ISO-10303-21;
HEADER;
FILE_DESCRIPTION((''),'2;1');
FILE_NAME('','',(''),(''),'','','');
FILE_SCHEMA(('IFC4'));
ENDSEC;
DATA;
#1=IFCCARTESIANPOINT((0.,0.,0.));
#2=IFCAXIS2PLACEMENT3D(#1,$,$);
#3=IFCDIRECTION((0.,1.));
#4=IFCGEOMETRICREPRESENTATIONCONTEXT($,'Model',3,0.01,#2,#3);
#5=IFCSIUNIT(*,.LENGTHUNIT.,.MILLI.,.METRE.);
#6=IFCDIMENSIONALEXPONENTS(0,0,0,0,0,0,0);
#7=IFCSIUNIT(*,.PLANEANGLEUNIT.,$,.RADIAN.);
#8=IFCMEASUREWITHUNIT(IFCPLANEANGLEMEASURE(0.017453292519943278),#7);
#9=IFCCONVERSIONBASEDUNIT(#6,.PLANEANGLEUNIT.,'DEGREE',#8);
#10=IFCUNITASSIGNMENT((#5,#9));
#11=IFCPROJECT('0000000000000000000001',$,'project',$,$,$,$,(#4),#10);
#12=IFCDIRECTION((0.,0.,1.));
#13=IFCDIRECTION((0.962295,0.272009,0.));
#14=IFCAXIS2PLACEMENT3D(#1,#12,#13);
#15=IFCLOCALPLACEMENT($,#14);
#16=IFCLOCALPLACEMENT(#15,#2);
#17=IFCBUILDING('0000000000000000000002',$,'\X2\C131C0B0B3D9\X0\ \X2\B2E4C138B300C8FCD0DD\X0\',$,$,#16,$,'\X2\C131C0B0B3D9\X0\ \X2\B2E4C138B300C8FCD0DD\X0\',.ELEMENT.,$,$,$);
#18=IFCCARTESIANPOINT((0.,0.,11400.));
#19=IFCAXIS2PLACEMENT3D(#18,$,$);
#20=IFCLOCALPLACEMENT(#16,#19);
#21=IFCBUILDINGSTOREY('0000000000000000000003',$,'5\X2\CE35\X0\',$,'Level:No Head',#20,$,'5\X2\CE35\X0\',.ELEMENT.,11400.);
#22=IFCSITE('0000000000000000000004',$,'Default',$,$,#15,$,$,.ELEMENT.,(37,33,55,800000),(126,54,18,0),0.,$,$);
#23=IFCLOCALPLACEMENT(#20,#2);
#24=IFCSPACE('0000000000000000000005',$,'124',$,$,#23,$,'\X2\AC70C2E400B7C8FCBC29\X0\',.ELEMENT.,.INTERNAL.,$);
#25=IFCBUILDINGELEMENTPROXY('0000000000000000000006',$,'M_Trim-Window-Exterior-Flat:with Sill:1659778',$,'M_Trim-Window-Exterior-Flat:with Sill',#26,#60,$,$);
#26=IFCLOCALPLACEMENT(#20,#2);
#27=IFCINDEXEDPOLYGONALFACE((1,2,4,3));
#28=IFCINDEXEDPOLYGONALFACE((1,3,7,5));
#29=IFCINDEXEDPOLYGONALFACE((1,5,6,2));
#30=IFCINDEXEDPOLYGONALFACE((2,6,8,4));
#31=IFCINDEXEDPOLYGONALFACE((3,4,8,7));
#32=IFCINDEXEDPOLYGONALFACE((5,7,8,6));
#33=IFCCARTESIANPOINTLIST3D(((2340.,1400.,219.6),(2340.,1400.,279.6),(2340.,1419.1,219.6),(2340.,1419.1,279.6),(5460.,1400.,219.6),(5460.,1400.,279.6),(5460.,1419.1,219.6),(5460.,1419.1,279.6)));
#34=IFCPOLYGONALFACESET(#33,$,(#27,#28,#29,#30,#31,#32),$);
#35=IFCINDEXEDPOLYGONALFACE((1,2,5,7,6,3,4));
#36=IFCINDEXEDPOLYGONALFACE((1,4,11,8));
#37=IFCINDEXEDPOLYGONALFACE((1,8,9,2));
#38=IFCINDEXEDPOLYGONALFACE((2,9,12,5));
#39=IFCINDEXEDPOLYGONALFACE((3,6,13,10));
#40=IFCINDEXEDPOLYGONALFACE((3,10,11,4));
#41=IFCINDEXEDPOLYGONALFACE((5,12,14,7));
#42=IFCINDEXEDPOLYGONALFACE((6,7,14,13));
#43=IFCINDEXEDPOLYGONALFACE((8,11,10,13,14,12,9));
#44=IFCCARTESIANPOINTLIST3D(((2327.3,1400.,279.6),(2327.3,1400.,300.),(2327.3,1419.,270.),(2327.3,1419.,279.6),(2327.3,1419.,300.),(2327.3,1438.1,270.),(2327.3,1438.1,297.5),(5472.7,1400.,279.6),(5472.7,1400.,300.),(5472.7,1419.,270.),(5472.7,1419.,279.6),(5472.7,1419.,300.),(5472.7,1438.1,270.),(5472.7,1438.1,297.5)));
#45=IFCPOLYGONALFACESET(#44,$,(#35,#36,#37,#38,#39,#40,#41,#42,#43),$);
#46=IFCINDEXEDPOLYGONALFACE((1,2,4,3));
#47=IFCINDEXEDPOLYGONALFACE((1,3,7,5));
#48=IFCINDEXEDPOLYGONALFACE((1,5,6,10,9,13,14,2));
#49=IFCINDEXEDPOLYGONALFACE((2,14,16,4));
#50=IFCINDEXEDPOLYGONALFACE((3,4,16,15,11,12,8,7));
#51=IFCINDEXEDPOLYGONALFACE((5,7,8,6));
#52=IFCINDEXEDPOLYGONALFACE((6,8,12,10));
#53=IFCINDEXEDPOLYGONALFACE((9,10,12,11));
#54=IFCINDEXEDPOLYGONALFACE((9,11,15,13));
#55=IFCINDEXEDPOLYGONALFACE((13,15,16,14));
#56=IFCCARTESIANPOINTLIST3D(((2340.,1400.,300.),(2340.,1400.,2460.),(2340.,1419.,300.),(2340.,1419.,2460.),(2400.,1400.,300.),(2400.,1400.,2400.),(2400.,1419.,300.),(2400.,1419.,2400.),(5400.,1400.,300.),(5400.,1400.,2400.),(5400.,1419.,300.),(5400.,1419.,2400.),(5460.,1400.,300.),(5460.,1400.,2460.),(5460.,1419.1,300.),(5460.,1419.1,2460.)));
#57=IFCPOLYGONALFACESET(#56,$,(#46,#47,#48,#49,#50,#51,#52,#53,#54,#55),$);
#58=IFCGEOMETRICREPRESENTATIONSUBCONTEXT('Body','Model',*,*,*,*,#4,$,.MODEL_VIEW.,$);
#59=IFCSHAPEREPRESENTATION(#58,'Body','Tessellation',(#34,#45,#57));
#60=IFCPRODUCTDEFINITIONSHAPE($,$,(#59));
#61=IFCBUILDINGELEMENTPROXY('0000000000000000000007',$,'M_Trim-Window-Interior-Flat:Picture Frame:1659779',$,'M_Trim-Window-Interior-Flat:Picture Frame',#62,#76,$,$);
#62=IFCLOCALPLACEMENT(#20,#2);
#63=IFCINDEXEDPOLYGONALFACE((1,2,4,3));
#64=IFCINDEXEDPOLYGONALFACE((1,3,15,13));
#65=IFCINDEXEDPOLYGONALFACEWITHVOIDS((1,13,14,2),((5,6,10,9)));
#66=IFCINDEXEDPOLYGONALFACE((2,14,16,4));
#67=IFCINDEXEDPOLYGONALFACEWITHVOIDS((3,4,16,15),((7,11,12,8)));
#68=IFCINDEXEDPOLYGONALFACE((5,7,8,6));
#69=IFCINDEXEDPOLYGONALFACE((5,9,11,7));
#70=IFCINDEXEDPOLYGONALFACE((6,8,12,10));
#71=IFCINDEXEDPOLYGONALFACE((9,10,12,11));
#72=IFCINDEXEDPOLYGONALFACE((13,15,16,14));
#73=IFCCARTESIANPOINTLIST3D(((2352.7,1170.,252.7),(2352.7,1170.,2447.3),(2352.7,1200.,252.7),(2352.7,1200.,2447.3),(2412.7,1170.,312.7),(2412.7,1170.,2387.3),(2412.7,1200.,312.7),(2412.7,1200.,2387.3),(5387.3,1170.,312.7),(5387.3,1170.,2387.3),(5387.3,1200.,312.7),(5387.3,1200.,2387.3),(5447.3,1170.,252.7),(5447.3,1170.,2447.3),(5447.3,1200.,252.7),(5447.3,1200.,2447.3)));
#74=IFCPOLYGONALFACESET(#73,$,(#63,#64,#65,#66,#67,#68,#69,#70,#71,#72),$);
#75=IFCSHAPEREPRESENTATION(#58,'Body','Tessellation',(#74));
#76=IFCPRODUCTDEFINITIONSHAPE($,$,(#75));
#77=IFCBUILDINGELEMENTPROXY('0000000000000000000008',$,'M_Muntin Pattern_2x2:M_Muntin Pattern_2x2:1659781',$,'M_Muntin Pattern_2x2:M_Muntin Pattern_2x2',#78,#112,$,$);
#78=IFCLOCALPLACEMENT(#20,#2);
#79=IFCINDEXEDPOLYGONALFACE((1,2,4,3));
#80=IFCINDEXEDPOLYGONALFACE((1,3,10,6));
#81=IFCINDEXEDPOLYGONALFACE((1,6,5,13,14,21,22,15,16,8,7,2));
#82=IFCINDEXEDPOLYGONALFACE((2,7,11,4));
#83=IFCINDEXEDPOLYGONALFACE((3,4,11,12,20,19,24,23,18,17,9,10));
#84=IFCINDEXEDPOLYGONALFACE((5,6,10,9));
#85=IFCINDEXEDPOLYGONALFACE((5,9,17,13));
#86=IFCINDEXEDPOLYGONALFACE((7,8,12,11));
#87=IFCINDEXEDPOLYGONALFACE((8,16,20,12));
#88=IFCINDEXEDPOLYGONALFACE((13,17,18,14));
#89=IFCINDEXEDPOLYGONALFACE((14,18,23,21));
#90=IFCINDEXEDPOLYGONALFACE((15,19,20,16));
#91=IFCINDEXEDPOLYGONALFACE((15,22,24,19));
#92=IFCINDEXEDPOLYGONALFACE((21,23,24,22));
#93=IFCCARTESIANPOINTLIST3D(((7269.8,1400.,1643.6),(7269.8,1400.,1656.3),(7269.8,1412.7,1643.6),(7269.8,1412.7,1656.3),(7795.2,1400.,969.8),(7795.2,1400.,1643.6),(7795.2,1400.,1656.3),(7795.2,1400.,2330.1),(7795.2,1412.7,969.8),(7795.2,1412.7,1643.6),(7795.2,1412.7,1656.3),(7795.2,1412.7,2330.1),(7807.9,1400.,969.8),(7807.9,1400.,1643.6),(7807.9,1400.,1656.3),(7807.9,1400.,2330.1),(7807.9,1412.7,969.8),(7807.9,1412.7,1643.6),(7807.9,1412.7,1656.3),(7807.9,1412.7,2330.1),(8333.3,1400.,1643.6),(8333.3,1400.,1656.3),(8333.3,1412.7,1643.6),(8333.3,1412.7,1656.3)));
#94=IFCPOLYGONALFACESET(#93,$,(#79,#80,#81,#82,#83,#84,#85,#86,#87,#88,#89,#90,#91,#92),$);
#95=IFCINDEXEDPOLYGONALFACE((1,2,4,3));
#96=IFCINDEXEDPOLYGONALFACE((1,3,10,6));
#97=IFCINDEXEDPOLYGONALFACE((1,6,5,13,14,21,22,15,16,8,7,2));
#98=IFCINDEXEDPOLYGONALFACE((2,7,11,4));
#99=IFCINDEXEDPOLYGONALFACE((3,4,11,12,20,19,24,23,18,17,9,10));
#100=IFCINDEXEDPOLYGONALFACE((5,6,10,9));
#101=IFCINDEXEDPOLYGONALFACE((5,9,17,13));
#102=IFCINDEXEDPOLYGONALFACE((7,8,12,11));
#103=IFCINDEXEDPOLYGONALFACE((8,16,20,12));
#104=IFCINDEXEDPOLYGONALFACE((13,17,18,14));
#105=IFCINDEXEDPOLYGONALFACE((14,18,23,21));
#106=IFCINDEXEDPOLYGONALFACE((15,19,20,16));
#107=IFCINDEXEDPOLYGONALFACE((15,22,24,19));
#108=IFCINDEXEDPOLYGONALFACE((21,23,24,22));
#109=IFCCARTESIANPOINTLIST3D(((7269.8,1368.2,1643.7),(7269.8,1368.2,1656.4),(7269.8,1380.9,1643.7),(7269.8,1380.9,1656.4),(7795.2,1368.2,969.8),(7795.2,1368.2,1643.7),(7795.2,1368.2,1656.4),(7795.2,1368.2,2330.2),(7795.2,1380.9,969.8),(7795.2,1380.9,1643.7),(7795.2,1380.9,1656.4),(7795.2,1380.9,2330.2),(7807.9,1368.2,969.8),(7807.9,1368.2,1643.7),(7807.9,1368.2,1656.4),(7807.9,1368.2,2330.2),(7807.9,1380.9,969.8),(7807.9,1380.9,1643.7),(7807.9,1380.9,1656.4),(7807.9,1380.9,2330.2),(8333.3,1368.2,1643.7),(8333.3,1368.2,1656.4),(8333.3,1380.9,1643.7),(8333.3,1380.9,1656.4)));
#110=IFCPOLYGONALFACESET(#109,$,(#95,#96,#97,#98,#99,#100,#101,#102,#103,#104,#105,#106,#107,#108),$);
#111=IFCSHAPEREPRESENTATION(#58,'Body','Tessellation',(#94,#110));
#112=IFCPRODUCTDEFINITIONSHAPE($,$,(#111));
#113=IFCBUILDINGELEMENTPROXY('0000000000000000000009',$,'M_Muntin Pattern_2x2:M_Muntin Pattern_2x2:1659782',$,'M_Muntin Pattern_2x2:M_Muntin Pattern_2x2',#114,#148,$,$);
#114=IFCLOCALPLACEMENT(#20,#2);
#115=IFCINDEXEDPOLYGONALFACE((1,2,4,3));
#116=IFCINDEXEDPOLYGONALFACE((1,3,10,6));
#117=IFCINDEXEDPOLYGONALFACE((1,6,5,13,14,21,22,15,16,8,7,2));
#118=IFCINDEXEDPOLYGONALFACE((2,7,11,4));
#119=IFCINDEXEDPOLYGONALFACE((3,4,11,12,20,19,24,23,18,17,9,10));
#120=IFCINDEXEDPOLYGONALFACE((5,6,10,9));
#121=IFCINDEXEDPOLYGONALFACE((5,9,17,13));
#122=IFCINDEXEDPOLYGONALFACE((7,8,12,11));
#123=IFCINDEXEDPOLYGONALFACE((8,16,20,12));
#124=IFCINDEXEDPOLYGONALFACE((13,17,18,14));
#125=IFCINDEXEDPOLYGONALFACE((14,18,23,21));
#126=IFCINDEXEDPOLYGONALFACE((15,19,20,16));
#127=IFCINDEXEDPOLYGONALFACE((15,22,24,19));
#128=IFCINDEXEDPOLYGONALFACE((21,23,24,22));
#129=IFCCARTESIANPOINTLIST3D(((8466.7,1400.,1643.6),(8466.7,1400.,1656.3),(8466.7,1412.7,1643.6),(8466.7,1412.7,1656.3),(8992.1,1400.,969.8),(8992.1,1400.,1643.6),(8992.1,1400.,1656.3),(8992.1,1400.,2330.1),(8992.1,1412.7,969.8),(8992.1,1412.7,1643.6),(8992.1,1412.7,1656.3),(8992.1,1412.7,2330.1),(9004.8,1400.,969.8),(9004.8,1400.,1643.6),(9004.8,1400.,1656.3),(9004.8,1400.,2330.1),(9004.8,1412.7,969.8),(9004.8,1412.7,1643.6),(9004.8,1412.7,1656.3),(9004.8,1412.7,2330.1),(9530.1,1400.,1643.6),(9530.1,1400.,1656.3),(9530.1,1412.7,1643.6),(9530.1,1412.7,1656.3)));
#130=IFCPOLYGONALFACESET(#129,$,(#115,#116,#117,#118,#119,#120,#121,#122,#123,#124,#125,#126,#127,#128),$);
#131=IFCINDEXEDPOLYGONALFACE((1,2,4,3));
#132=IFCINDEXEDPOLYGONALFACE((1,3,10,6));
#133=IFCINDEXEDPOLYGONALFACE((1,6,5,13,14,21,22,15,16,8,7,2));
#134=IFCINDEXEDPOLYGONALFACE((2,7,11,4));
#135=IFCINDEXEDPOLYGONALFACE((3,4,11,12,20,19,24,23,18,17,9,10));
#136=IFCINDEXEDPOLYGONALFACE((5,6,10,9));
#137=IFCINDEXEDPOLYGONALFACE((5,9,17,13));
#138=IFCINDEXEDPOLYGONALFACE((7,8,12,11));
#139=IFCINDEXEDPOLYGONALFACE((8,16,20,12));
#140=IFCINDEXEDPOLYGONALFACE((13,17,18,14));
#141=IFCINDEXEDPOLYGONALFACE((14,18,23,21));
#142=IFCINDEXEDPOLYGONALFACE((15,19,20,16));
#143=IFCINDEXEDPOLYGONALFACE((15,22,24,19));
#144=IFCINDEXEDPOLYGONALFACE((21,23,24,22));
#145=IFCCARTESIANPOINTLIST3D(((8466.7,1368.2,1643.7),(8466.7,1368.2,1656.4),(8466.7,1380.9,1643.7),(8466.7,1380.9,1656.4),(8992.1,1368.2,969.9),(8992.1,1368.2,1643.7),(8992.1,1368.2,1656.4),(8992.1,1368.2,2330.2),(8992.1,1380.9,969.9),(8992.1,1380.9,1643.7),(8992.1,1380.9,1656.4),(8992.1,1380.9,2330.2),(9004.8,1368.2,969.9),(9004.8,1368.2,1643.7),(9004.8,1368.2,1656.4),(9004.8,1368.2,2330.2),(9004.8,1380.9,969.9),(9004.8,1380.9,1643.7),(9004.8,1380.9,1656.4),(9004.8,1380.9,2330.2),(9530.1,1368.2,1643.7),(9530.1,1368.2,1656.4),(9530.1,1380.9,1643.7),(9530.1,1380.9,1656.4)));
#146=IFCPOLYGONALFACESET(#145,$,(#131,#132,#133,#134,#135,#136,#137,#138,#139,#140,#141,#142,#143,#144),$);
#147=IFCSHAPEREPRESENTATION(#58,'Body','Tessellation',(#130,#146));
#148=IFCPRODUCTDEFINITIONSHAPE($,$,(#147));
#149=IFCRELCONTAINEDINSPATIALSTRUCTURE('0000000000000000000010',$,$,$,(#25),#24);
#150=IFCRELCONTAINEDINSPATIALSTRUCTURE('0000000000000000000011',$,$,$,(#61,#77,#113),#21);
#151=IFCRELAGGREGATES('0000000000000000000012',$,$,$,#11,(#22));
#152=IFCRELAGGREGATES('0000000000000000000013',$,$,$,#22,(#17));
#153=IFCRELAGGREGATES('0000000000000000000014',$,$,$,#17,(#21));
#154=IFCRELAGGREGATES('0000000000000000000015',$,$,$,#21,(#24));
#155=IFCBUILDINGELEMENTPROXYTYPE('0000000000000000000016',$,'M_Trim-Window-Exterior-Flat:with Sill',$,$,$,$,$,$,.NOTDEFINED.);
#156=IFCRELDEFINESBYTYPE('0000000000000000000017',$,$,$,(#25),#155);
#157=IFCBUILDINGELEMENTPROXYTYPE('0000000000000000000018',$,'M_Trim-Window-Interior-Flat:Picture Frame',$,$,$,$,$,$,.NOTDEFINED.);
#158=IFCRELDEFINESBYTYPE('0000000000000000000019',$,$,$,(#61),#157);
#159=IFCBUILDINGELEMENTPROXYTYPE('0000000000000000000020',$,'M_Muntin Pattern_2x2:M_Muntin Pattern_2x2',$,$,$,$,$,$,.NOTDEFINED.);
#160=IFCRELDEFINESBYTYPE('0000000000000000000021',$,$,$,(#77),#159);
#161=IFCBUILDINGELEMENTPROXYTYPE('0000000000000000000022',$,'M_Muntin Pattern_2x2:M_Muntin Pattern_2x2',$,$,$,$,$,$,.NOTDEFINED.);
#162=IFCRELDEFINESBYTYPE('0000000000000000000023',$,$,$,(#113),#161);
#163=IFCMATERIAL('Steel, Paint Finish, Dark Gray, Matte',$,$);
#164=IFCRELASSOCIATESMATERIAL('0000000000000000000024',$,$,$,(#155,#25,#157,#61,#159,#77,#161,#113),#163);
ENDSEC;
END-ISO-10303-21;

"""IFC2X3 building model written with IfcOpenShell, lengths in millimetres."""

from ifc_helpers import new_model, entity, si_unit, converted_unit, direction, frame, frame_2d, origin, place, context, subcontext, project, spatial, polyline, rectangle, outline, extrude, source, transform, mapped, material, type_object, type_shapes, element, save


model = new_model("IFC2X3")

# Units and contexts
model_context = context("Model", 3, precision=0.01, world=origin(), true_north=direction((0.0, 1.0)))
body_context = subcontext(model_context, "Body", "Model", "MODEL_VIEW")
ifc_project = project(units=[si_unit("LENGTHUNIT", "METRE", prefix="MILLI"), converted_unit("PLANEANGLEUNIT", "DEGREE", entity("IfcPlaneAngleMeasure", 0.017453292519943278), si_unit("PLANEANGLEUNIT", "RADIAN"), dimensions=[0, 0, 0, 0, 0, 0, 0])], contexts=[model_context])

# Site, building, storey
site_placement = place(None, frame((0.0, 0.0, 0.0), z_axis=(0.0, 0.0, 1.0), x_axis=(0.962295, 0.272009, 0.0)))
site = spatial("IfcSite", under=ifc_project, at=site_placement, Name="Default", CompositionType="ELEMENT", RefLatitude=(37, 33, 55, 800000), RefLongitude=(126, 54, 18, 0), RefElevation=0.0)
building_placement = place(site_placement, origin())
building = spatial("IfcBuilding", under=site, at=building_placement, Name="성산동 다세대주택", LongName="성산동 다세대주택", CompositionType="ELEMENT")
storey_placement = place(building_placement, frame((0.0, 0.0, 11400.0)))
storey = spatial("IfcBuildingStorey", under=building, at=storey_placement, Name="5층", ObjectType="Level:No Head", LongName="5층", CompositionType="ELEMENT", Elevation=11400.0)

# Shared definitions
ifc_material_1 = material(Name="Steel, Paint Finish, Dark Gray, Matte")

# Shared definitions
space_1_placement = place(storey_placement, origin())
space_1 = spatial("IfcSpace", under=storey, at=space_1_placement, Name="124", LongName="거실·주방", CompositionType="ELEMENT", InteriorOrExteriorSpace="INTERNAL")

# Building element proxies
building_element_proxy_type_1 = type_object("IfcBuildingElementProxyType", Name="M_Trim-Window-Exterior-Flat:with Sill", PredefinedType="NOTDEFINED", material=ifc_material_1)
shared_shape_1 = source(origin(), body_context, "Body", "SweptSolid", [
    extrude(rectangle(XDim=3120.0, YDim=60.0, at=frame_2d((0.0, 0.0), x_axis=(1.0, 0.0))), frame((0.0, -2150.4, 0.0), z_axis=(0.0, 0.0, 1.0), x_axis=(-1.0, 0.0, 0.0)), (0.0, 0.0, 1.0), 19.0),
    extrude(outline(polyline([(-19.0, -15.2), (0.0, -15.2), (0.0, -5.7), (19.0, -5.7), (19.0, 14.8), (0.0, 14.8), (-19.0, 12.3), (-19.0, -15.2)])), frame((-1572.7, -2114.8, 19.0), z_axis=(1.0, 0.0, 0.0), x_axis=(0.0, 0.0, -1.0)), (0.0, 0.0, 1.0), 3145.4),
    extrude(outline(polyline([(-1095.0, -1560.0), (1065.0, -1560.0), (1065.0, -1500.0), (-1035.0, -1500.0), (-1035.0, 1500.0), (1065.0, 1500.0), (1065.0, 1560.0), (-1095.0, 1560.0), (-1095.0, -1560.0)])), frame((0.0, -1035.0, 0.0), z_axis=(0.0, 0.0, 1.0), x_axis=(0.0, -1.0, 0.0)), (0.0, 0.0, 1.0), 19.0),
])
type_shapes(building_element_proxy_type_1, [shared_shape_1])
proxy_1_placement = place(space_1_placement, frame((3900.0, 1400.0, 2400.0), z_axis=(0.0, 1.0, 0.0), x_axis=(-1.0, 0.0, 0.0)))
element("IfcBuildingElementProxy", 1, at=proxy_1_placement, inside=space_1, type_object=building_element_proxy_type_1, material=ifc_material_1, Name="M_Trim-Window-Exterior-Flat:with Sill:1659778", ObjectType="M_Trim-Window-Exterior-Flat:with Sill", context=body_context, shape_type="MappedRepresentation", body=[
    mapped(shared_shape_1, transform((0.0, 0.0, 0.0), scale=1.0)),
])
building_element_proxy_type_2 = type_object("IfcBuildingElementProxyType", Name="M_Trim-Window-Interior-Flat:Picture Frame", PredefinedType="NOTDEFINED", material=ifc_material_1)
shared_shape_2 = source(origin(), body_context, "Body", "SweptSolid", [
    extrude(outline(polyline([(-1547.3, -1097.3), (1547.3, -1097.3), (1547.3, 1097.3), (-1547.3, 1097.3), (-1547.3, -1097.3)]), holes=[polyline([(-1487.3, -1037.3), (-1487.3, 1037.3), (1487.3, 1037.3), (1487.3, -1037.3), (-1487.3, -1037.3)])]), frame((0.0, -1050.0, 0.0), z_axis=(0.0, 0.0, 1.0), x_axis=(-1.0, 0.0, 0.0)), (0.0, 0.0, 1.0), 30.0),
])
type_shapes(building_element_proxy_type_2, [shared_shape_2])
proxy_2_placement = place(storey_placement, frame((3900.0, 1200.0, 2400.0), z_axis=(0.0, -1.0, 0.0), x_axis=(1.0, 0.0, 0.0)))
element("IfcBuildingElementProxy", 2, at=proxy_2_placement, inside=storey, type_object=building_element_proxy_type_2, material=ifc_material_1, Name="M_Trim-Window-Interior-Flat:Picture Frame:1659779", ObjectType="M_Trim-Window-Interior-Flat:Picture Frame", context=body_context, shape_type="MappedRepresentation", body=[
    mapped(shared_shape_2, transform((0.0, 0.0, 0.0), scale=1.0)),
])
building_element_proxy_type_3 = type_object("IfcBuildingElementProxyType", Name="M_Muntin Pattern_2x2:M_Muntin Pattern_2x2", PredefinedType="NOTDEFINED", material=ifc_material_1)
shared_shape_3 = source(origin(), body_context, "Body", "SweptSolid", [
    extrude(outline(polyline([(6.4, -6.4), (680.1, -6.4), (680.1, 6.3), (6.4, 6.3), (6.4, 531.7), (-6.3, 531.7), (-6.3, 6.3), (-680.2, 6.3), (-680.2, -6.4), (-6.3, -6.4), (-6.3, -531.7), (6.4, -531.7), (6.4, -6.4)])), frame((0.0, 9.5, 680.1), z_axis=(0.0, 1.0, 0.0), x_axis=(0.0, 0.0, 1.0)), (0.0, 0.0, 1.0), 12.7),
    extrude(outline(polyline([(6.4, -6.4), (680.2, -6.4), (680.2, 6.3), (6.4, 6.3), (6.4, 531.7), (-6.3, 531.7), (-6.3, 6.3), (-680.2, 6.3), (-680.2, -6.4), (-6.3, -6.4), (-6.3, -531.7), (6.4, -531.7), (6.4, -6.4)])), frame((0.0, -22.2, 680.2), z_axis=(0.0, 1.0, 0.0), x_axis=(0.0, 0.0, 1.0)), (0.0, 0.0, 1.0), 12.7),
])
type_shapes(building_element_proxy_type_3, [shared_shape_3])
proxy_3_placement = place(storey_placement, frame((7801.6, 1390.5, 969.8)))
element("IfcBuildingElementProxy", 3, at=proxy_3_placement, inside=storey, type_object=building_element_proxy_type_3, material=ifc_material_1, Name="M_Muntin Pattern_2x2:M_Muntin Pattern_2x2:1659781", ObjectType="M_Muntin Pattern_2x2:M_Muntin Pattern_2x2", context=body_context, shape_type="MappedRepresentation", body=[
    mapped(shared_shape_3, transform((0.0, 0.0, 0.0), scale=1.0)),
])
building_element_proxy_type_4 = type_object("IfcBuildingElementProxyType", Name="M_Muntin Pattern_2x2:M_Muntin Pattern_2x2", PredefinedType="NOTDEFINED", material=ifc_material_1)
shared_shape_4 = source(origin(), body_context, "Body", "SweptSolid", [
    extrude(outline(polyline([(6.4, -6.4), (680.1, -6.4), (680.1, 6.3), (6.4, 6.3), (6.4, 531.7), (-6.3, 531.7), (-6.3, 6.3), (-680.2, 6.3), (-680.2, -6.4), (-6.3, -6.4), (-6.3, -531.7), (6.4, -531.7), (6.4, -6.4)])), frame((0.0, -22.2, 680.1), z_axis=(0.0, 1.0, 0.0), x_axis=(0.0, 0.0, 1.0)), (0.0, 0.0, 1.0), 12.7),
    extrude(outline(polyline([(6.4, -6.4), (680.2, -6.4), (680.2, 6.3), (6.4, 6.3), (6.4, 531.7), (-6.3, 531.7), (-6.3, 6.3), (-680.2, 6.3), (-680.2, -6.4), (-6.3, -6.4), (-6.3, -531.7), (6.4, -531.7), (6.4, -6.4)])), frame((0.0, 9.5, 680.2), z_axis=(0.0, 1.0, 0.0), x_axis=(0.0, 0.0, 1.0)), (0.0, 0.0, 1.0), 12.7),
])
type_shapes(building_element_proxy_type_4, [shared_shape_4])
proxy_4_placement = place(storey_placement, frame((8998.4, 1390.5, 969.9), z_axis=(0.0, 0.0, 1.0), x_axis=(-1.0, 0.0, 0.0)))
element("IfcBuildingElementProxy", 4, at=proxy_4_placement, inside=storey, type_object=building_element_proxy_type_4, material=ifc_material_1, Name="M_Muntin Pattern_2x2:M_Muntin Pattern_2x2:1659782", ObjectType="M_Muntin Pattern_2x2:M_Muntin Pattern_2x2", context=body_context, shape_type="MappedRepresentation", body=[
    mapped(shared_shape_4, transform((0.0, 0.0, 0.0), scale=1.0)),
])

save(model, "model.ifc")
